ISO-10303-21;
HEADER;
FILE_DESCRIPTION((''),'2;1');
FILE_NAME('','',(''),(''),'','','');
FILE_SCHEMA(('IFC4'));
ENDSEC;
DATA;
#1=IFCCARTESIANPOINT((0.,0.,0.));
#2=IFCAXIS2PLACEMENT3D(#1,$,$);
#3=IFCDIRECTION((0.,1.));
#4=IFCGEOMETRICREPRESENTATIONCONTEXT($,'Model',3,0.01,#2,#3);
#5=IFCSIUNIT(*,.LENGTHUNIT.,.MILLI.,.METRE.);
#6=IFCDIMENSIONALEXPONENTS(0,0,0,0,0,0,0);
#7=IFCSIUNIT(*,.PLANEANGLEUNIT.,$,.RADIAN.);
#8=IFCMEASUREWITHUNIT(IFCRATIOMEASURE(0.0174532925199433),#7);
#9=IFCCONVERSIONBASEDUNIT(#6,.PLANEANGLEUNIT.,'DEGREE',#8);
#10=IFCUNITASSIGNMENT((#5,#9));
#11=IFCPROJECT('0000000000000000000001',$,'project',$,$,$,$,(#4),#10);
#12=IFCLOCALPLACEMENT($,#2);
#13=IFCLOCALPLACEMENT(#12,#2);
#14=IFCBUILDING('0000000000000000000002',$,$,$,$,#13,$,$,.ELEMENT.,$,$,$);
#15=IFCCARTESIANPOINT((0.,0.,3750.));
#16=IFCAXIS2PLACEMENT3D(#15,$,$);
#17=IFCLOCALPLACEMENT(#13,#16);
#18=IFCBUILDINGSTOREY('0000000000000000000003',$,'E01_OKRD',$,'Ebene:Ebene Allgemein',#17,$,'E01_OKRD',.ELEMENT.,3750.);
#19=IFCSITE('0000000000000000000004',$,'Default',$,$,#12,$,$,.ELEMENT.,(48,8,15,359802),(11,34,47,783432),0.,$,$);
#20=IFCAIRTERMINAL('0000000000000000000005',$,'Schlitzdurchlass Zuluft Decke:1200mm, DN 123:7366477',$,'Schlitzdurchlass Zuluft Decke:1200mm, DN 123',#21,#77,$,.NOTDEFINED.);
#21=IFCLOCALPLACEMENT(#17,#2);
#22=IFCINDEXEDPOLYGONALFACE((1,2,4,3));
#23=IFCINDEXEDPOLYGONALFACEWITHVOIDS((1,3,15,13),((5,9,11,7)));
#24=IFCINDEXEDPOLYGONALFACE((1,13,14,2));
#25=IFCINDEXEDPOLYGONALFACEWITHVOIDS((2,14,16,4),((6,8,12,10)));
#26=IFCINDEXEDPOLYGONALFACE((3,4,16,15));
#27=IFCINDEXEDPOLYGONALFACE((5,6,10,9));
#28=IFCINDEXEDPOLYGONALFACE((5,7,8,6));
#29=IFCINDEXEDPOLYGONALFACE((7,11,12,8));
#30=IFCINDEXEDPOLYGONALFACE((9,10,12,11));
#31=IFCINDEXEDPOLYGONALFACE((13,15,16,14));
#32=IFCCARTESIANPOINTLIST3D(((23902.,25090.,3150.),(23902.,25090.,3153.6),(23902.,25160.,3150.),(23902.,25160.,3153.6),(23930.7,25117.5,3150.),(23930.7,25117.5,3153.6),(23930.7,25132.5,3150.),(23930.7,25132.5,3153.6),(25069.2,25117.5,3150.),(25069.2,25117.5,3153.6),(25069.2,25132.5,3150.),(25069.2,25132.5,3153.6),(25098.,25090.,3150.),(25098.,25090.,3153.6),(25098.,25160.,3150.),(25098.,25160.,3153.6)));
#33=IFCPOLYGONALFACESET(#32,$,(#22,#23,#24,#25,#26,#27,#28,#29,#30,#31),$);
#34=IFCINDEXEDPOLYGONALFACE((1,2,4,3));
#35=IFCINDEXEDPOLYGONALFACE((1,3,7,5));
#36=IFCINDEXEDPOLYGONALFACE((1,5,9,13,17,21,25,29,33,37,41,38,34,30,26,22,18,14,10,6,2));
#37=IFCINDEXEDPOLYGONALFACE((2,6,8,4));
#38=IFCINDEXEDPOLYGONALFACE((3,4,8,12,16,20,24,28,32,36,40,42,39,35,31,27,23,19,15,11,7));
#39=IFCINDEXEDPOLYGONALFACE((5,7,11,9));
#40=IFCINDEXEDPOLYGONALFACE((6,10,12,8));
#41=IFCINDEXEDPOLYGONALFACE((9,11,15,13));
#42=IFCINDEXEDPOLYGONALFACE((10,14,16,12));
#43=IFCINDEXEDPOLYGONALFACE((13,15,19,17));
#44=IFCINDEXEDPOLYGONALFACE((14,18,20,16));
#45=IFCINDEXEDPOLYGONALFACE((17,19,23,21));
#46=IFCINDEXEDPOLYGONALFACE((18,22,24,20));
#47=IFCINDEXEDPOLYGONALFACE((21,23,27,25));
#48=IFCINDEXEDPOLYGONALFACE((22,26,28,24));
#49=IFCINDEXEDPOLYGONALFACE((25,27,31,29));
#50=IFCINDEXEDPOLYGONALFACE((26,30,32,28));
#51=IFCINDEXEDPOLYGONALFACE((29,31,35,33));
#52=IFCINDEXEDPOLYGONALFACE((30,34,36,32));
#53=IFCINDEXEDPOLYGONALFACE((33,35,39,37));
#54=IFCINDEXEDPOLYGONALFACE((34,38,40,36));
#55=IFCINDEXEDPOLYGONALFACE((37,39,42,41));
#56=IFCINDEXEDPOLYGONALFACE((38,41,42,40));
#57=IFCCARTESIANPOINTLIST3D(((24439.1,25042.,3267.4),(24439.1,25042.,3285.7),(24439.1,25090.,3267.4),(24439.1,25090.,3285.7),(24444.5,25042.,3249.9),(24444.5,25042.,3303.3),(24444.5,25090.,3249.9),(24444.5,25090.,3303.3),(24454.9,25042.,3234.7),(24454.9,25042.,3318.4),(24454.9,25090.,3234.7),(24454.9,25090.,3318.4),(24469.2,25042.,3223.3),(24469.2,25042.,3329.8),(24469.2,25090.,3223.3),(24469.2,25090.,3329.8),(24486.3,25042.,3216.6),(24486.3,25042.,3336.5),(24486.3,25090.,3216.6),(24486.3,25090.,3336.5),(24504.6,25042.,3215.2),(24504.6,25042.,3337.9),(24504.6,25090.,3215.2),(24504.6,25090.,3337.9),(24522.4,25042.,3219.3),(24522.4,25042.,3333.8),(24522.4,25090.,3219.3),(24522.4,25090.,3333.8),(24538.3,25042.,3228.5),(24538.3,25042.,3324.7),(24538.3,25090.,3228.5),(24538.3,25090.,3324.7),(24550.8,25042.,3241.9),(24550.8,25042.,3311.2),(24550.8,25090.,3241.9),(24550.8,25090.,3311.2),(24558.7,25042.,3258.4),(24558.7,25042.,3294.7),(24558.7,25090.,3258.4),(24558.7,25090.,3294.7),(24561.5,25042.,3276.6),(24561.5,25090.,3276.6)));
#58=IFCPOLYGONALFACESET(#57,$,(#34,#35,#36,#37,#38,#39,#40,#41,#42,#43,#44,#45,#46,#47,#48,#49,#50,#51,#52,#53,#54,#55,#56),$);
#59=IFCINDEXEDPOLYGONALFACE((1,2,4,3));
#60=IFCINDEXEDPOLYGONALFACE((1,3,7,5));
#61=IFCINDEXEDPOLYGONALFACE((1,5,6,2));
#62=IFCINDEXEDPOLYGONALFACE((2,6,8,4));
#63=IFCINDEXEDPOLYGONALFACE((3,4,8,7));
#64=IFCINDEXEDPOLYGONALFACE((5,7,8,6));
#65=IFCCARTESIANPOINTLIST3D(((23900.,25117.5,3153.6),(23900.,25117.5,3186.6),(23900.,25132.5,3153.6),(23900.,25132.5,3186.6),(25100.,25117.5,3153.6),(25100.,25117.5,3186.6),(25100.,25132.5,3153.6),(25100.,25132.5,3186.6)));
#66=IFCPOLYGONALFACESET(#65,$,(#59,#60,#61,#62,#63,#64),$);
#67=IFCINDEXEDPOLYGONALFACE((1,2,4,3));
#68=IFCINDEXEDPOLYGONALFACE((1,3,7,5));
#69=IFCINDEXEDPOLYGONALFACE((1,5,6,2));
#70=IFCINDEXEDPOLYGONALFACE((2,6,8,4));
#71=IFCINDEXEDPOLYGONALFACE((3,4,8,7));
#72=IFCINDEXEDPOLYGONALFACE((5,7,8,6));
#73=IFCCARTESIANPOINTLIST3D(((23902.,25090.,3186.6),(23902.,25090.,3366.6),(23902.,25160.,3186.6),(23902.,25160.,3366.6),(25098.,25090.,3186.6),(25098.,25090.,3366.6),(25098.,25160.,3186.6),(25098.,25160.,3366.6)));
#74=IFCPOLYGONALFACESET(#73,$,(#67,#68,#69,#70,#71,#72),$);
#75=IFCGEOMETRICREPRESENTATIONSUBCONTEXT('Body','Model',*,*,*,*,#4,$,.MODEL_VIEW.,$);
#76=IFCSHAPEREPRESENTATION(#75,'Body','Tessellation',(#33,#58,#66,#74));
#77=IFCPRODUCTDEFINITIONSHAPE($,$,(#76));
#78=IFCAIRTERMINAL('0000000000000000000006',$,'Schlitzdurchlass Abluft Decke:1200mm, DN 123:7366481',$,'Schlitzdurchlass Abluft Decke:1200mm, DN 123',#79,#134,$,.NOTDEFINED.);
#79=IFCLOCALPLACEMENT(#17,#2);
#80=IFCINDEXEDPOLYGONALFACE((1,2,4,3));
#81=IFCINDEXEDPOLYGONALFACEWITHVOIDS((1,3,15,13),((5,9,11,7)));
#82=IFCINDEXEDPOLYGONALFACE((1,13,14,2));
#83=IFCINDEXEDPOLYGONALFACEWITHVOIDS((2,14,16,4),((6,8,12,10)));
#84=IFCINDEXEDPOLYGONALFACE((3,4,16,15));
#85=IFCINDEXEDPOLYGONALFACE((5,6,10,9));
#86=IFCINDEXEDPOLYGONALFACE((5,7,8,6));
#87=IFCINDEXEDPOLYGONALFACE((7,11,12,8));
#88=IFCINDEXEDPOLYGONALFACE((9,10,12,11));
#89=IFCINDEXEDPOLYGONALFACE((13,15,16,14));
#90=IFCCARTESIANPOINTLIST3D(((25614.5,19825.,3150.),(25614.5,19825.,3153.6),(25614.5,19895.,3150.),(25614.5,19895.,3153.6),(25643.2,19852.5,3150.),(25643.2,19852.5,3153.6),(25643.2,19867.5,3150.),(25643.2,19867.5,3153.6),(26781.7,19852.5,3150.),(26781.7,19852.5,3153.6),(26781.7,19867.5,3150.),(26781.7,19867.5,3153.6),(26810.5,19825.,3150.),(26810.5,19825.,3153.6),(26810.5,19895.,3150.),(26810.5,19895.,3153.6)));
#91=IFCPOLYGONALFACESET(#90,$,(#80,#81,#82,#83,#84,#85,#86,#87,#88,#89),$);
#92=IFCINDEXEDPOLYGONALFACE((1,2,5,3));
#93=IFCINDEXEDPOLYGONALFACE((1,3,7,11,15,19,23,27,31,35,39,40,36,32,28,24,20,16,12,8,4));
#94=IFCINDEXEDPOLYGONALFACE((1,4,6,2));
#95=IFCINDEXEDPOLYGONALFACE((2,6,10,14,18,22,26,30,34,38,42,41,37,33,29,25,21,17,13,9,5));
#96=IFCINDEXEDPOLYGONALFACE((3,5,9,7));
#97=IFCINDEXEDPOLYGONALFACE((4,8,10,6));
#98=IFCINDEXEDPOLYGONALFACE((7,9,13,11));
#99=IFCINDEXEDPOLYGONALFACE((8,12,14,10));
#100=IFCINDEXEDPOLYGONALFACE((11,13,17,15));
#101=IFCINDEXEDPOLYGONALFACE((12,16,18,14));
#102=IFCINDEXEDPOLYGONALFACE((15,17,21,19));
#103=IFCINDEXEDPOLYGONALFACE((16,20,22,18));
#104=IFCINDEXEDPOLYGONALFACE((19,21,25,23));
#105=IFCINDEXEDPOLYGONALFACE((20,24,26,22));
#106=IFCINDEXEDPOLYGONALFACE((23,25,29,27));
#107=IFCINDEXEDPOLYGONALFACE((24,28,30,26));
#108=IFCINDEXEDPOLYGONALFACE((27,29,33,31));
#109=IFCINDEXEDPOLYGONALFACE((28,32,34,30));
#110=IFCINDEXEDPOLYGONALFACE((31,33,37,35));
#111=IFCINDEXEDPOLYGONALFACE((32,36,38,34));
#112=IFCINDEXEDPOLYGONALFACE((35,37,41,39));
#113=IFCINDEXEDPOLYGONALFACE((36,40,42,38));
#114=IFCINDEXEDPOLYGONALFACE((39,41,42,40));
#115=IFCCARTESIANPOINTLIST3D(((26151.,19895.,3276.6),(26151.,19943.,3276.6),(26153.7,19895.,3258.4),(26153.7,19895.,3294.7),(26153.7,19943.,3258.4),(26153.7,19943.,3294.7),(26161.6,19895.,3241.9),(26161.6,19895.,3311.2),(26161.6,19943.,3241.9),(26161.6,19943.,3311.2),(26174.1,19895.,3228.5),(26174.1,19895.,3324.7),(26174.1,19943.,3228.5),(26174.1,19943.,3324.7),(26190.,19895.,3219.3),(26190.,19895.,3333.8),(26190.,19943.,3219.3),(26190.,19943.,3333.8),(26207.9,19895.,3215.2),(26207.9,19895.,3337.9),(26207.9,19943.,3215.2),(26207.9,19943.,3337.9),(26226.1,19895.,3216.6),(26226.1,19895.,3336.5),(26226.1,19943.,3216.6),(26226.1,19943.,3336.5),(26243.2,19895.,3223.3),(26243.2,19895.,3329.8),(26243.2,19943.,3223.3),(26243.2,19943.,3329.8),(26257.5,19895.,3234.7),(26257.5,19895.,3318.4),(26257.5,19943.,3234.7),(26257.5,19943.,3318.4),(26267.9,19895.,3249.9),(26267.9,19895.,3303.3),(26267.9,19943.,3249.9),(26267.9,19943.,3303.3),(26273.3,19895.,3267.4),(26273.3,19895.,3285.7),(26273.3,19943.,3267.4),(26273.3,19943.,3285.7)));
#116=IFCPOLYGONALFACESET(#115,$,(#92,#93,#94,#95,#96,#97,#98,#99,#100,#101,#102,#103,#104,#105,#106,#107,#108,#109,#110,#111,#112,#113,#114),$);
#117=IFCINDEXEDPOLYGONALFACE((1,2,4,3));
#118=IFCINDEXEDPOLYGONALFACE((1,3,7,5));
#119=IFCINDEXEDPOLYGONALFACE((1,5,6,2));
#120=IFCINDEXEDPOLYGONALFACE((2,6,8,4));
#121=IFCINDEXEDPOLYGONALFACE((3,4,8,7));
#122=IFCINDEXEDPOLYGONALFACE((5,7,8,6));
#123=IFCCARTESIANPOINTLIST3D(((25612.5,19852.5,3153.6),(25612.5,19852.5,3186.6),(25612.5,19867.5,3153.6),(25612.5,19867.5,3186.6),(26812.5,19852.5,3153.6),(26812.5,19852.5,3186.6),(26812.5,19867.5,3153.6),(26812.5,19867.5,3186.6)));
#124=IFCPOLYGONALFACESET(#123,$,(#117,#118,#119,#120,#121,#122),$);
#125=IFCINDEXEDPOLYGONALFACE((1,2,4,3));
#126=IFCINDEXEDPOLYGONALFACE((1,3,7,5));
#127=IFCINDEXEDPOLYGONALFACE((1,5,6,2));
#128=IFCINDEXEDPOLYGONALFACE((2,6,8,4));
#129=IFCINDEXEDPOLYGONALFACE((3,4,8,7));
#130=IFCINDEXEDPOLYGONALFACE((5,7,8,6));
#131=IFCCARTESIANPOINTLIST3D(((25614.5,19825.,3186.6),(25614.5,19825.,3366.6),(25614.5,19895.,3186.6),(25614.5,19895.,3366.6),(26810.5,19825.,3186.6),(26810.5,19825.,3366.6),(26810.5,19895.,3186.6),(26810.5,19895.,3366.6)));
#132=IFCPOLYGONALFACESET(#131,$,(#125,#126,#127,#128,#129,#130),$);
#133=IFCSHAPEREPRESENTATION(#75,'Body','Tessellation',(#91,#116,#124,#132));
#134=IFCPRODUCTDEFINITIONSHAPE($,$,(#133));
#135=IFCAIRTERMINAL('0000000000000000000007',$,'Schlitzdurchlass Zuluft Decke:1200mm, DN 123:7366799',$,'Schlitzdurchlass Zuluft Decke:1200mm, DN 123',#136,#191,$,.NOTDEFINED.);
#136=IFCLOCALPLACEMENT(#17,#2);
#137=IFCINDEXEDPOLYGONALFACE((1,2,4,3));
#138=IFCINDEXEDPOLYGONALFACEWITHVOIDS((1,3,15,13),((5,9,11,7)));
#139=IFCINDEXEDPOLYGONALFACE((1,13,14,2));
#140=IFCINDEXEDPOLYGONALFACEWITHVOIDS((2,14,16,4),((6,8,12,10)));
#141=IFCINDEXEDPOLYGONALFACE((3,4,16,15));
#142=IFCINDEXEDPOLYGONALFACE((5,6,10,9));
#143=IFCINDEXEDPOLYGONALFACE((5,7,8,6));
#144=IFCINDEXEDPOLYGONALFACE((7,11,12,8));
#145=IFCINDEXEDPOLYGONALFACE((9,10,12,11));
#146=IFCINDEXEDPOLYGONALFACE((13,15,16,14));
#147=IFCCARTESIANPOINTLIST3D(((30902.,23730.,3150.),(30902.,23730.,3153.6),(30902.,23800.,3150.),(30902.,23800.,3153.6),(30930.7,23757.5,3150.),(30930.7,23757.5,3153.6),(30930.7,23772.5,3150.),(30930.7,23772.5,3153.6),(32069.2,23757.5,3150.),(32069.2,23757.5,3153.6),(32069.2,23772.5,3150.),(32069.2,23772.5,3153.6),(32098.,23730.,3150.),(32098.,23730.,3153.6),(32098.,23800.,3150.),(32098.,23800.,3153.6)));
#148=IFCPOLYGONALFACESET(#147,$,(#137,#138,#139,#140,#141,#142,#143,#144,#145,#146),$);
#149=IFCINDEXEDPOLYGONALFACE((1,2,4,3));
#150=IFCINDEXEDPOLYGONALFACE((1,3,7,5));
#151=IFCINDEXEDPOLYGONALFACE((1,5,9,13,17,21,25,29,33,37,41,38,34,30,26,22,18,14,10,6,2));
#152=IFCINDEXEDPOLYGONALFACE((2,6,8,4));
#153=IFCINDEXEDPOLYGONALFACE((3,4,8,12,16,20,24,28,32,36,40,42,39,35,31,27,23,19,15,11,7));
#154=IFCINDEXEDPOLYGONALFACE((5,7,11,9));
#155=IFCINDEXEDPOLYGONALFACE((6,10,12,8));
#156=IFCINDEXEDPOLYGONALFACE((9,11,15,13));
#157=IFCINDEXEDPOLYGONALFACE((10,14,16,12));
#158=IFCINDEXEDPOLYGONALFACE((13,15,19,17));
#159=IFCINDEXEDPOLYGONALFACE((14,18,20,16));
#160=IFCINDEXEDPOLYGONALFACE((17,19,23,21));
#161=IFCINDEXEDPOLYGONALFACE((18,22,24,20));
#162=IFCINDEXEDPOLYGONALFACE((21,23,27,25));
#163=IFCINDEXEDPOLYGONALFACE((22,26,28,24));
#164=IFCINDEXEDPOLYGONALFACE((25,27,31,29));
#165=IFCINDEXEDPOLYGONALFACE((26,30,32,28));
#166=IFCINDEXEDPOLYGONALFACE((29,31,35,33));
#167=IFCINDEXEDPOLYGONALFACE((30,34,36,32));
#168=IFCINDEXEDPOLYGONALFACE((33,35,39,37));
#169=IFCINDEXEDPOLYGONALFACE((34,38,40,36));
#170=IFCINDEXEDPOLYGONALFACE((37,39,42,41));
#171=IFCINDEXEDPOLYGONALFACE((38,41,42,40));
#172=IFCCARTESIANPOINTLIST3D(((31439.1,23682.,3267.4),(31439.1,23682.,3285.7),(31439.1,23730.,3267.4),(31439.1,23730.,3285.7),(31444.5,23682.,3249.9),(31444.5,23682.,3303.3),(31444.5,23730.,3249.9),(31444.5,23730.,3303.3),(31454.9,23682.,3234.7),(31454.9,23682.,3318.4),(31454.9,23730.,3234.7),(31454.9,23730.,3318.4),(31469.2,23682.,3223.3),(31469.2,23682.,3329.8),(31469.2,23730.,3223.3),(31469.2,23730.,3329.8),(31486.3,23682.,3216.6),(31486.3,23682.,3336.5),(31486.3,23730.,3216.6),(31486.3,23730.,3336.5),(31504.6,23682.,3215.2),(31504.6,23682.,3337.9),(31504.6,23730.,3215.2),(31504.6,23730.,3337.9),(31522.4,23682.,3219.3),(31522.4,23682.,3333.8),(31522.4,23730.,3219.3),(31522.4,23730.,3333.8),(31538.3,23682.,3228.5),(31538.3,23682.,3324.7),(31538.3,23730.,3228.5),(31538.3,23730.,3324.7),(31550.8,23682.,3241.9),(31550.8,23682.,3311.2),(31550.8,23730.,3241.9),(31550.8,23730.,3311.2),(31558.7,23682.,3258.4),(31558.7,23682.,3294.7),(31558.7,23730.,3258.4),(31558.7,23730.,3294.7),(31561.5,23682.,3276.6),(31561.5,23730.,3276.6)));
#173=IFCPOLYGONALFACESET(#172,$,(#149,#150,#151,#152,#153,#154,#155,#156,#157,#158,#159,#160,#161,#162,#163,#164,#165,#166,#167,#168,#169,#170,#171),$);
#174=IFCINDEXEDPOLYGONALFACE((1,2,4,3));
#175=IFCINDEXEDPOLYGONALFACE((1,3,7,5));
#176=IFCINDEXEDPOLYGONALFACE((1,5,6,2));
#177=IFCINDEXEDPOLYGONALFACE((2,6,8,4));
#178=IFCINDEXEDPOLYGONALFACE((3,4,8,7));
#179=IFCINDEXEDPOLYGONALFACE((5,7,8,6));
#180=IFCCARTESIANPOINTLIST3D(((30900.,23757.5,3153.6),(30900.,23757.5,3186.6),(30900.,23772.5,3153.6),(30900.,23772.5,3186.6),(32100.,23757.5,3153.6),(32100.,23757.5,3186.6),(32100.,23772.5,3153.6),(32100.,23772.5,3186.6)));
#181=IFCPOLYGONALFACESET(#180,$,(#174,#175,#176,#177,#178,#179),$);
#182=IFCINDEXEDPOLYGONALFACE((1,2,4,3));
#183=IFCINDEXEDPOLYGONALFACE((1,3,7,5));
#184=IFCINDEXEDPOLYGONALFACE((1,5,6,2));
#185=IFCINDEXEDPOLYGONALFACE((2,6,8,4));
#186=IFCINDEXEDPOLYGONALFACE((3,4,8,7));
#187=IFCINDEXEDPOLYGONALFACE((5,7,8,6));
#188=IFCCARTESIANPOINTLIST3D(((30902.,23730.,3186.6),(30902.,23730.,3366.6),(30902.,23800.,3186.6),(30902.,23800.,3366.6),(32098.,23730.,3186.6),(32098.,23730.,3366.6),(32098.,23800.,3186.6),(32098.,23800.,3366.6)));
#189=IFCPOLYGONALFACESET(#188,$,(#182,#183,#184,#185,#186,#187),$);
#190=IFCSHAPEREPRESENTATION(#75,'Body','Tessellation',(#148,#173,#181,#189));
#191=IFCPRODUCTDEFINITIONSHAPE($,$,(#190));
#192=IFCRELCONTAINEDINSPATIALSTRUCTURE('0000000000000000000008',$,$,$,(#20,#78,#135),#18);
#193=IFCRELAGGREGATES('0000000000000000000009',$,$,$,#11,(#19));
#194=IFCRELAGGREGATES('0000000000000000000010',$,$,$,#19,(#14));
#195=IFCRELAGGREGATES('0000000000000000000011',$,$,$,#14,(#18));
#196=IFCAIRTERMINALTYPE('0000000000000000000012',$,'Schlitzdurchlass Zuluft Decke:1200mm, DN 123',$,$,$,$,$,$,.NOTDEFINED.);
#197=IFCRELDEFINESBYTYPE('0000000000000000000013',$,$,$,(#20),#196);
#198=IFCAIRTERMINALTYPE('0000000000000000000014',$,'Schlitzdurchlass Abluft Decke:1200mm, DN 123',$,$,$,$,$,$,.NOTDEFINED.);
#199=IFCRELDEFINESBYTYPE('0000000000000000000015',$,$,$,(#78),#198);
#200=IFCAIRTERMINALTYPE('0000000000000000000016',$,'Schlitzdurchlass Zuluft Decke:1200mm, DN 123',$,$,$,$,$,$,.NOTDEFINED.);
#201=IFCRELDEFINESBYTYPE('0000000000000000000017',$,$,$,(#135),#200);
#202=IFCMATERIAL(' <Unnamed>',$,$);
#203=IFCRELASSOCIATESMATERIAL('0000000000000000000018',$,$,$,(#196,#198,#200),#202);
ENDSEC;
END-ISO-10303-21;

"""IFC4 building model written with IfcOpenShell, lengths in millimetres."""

from ifc_helpers import new_model, entity, si_unit, converted_unit, direction, frame, frame_2d, origin, origin_2d_with_axis, place, context, subcontext, project, spatial, polyline, rectangle, circle, outline, extrude, source, transform, mapped, material, type_object, type_shapes, element, save


model = new_model("IFC4")

# Units and contexts
model_context = context("Model", 3, precision=0.01, world=origin(), true_north=direction((0.0, 1.0)))
body_context = subcontext(model_context, "Body", "Model", "MODEL_VIEW")
ifc_project = project(units=[si_unit("LENGTHUNIT", "METRE", prefix="MILLI"), converted_unit("PLANEANGLEUNIT", "DEGREE", entity("IfcRatioMeasure", 0.0174532925199433), si_unit("PLANEANGLEUNIT", "RADIAN"), dimensions=[0, 0, 0, 0, 0, 0, 0])], contexts=[model_context])

# Site, building, storey
site_placement = place(None, origin())
site = spatial("IfcSite", under=ifc_project, at=site_placement, Name="Default", CompositionType="ELEMENT", RefLatitude=(48, 8, 15, 359802), RefLongitude=(11, 34, 47, 783432), RefElevation=0.0)
building_placement = place(site_placement, origin())
building = spatial("IfcBuilding", under=site, at=building_placement, CompositionType="ELEMENT")
storey_placement = place(building_placement, frame((0.0, 0.0, 3750.0)))
storey = spatial("IfcBuildingStorey", under=building, at=storey_placement, Name="E01_OKRD", ObjectType="Ebene:Ebene Allgemein", LongName="E01_OKRD", CompositionType="ELEMENT", Elevation=3750.0)

# Air terminals
ifc_material_1 = material(Name=" <Unnamed>")
air_terminal_type_1 = type_object("IfcAirTerminalType", Name="Schlitzdurchlass Zuluft Decke:1200mm, DN 123", PredefinedType="NOTDEFINED", material=ifc_material_1)
shared_shape_1 = source(origin(), body_context, "Body", "SweptSolid", [
    extrude(outline(polyline([(-598.0, -35.0), (598.0, -35.0), (598.0, 35.0), (-598.0, 35.0), (-598.0, -35.0)]), holes=[polyline([(-569.2, -7.5), (-569.2, 7.5), (569.2, 7.5), (569.2, -7.5), (-569.2, -7.5)])]), frame((600.0, 35.0, 0.0), z_axis=(0.0, 0.0, 1.0), x_axis=(-1.0, 0.0, 0.0)), (0.0, 0.0, 1.0), 3.6),
    extrude(circle(Radius=61.5, at=frame_2d((0.0, 0.0), x_axis=(1.0, 0.0))), frame((600.0, 70.0, 126.6), z_axis=(0.0, 1.0, 0.0), x_axis=(-1.0, 0.0, 0.0)), (0.0, 0.0, 1.0), 48.0),
    extrude(rectangle(XDim=1200.0, YDim=15.0, at=origin_2d_with_axis()), frame((600.0, 35.0, 3.6), z_axis=(0.0, 0.0, 1.0), x_axis=(-1.0, 0.0, 0.0)), (0.0, 0.0, 1.0), 33.0),
    extrude(rectangle(XDim=1196.0, YDim=70.0, at=origin_2d_with_axis()), frame((600.0, 35.0, 36.6), z_axis=(0.0, 0.0, 1.0), x_axis=(-1.0, 0.0, 0.0)), (0.0, 0.0, 1.0), 180.0),
])
type_shapes(air_terminal_type_1, [shared_shape_1])
air_terminal_1_placement = place(storey_placement, frame((25100.0, 25160.0, 3150.0), z_axis=(0.0, 0.0, 1.0), x_axis=(-1.0, 0.0, 0.0)))
element("IfcAirTerminal", 1, at=air_terminal_1_placement, inside=storey, type_object=air_terminal_type_1, Name="Schlitzdurchlass Zuluft Decke:1200mm, DN 123:7366477", ObjectType="Schlitzdurchlass Zuluft Decke:1200mm, DN 123", PredefinedType="NOTDEFINED", context=body_context, shape_type="MappedRepresentation", body=[
    mapped(shared_shape_1, transform((0.0, 0.0, 0.0), scale=1.0)),
])
air_terminal_type_2 = type_object("IfcAirTerminalType", Name="Schlitzdurchlass Abluft Decke:1200mm, DN 123", PredefinedType="NOTDEFINED", material=ifc_material_1)
shared_shape_2 = source(origin(), body_context, "Body", "SweptSolid", [
    extrude(outline(polyline([(-598.0, -35.0), (598.0, -35.0), (598.0, 35.0), (-598.0, 35.0), (-598.0, -35.0)]), holes=[polyline([(-569.2, -7.5), (-569.2, 7.5), (569.2, 7.5), (569.2, -7.5), (-569.2, -7.5)])]), frame((0.0, 0.0, 0.0), z_axis=(0.0, 0.0, 1.0), x_axis=(-1.0, 0.0, 0.0)), (0.0, 0.0, 1.0), 3.6),
    extrude(circle(Radius=61.5, at=frame_2d((0.0, 0.0), x_axis=(1.0, 0.0))), frame((0.0, 35.0, 126.6), z_axis=(0.0, 1.0, 0.0), x_axis=(-1.0, 0.0, 0.0)), (0.0, 0.0, 1.0), 48.0),
    extrude(rectangle(XDim=1200.0, YDim=15.0, at=origin_2d_with_axis()), frame((0.0, 0.0, 3.6), z_axis=(0.0, 0.0, 1.0), x_axis=(-1.0, 0.0, 0.0)), (0.0, 0.0, 1.0), 33.0),
    extrude(rectangle(XDim=1196.0, YDim=70.0, at=origin_2d_with_axis()), frame((0.0, 0.0, 36.6), z_axis=(0.0, 0.0, 1.0), x_axis=(-1.0, 0.0, 0.0)), (0.0, 0.0, 1.0), 180.0),
])
type_shapes(air_terminal_type_2, [shared_shape_2])
air_terminal_2_placement = place(storey_placement, frame((26212.5, 19860.0, 3150.0)))
element("IfcAirTerminal", 2, at=air_terminal_2_placement, inside=storey, type_object=air_terminal_type_2, Name="Schlitzdurchlass Abluft Decke:1200mm, DN 123:7366481", ObjectType="Schlitzdurchlass Abluft Decke:1200mm, DN 123", PredefinedType="NOTDEFINED", context=body_context, shape_type="MappedRepresentation", body=[
    mapped(shared_shape_2, transform((0.0, 0.0, 0.0), scale=1.0)),
])

# Air terminal
air_terminal_type_3 = type_object("IfcAirTerminalType", Name="Schlitzdurchlass Zuluft Decke:1200mm, DN 123", PredefinedType="NOTDEFINED", material=ifc_material_1)
shared_shape_3 = source(origin(), body_context, "Body", "SweptSolid", [
    extrude(outline(polyline([(-598.0, -35.0), (598.0, -35.0), (598.0, 35.0), (-598.0, 35.0), (-598.0, -35.0)]), holes=[polyline([(-569.2, -7.5), (-569.2, 7.5), (569.2, 7.5), (569.2, -7.5), (-569.2, -7.5)])]), frame((600.0, 35.0, 0.0), z_axis=(0.0, 0.0, 1.0), x_axis=(-1.0, 0.0, 0.0)), (0.0, 0.0, 1.0), 3.6),
    extrude(circle(Radius=61.5, at=frame_2d((0.0, 0.0), x_axis=(1.0, 0.0))), frame((600.0, 70.0, 126.6), z_axis=(0.0, 1.0, 0.0), x_axis=(-1.0, 0.0, 0.0)), (0.0, 0.0, 1.0), 48.0),
    extrude(rectangle(XDim=1200.0, YDim=15.0, at=origin_2d_with_axis()), frame((600.0, 35.0, 3.6), z_axis=(0.0, 0.0, 1.0), x_axis=(-1.0, 0.0, 0.0)), (0.0, 0.0, 1.0), 33.0),
    extrude(rectangle(XDim=1196.0, YDim=70.0, at=origin_2d_with_axis()), frame((600.0, 35.0, 36.6), z_axis=(0.0, 0.0, 1.0), x_axis=(-1.0, 0.0, 0.0)), (0.0, 0.0, 1.0), 180.0),
])
type_shapes(air_terminal_type_3, [shared_shape_3])
air_terminal_3_placement = place(storey_placement, frame((32100.0, 23800.0, 3150.0), z_axis=(0.0, 0.0, 1.0), x_axis=(-1.0, 0.0, 0.0)))
element("IfcAirTerminal", 3, at=air_terminal_3_placement, inside=storey, type_object=air_terminal_type_3, Name="Schlitzdurchlass Zuluft Decke:1200mm, DN 123:7366799", ObjectType="Schlitzdurchlass Zuluft Decke:1200mm, DN 123", PredefinedType="NOTDEFINED", context=body_context, shape_type="MappedRepresentation", body=[
    mapped(shared_shape_3, transform((0.0, 0.0, 0.0), scale=1.0)),
])

save(model, "model.ifc")
